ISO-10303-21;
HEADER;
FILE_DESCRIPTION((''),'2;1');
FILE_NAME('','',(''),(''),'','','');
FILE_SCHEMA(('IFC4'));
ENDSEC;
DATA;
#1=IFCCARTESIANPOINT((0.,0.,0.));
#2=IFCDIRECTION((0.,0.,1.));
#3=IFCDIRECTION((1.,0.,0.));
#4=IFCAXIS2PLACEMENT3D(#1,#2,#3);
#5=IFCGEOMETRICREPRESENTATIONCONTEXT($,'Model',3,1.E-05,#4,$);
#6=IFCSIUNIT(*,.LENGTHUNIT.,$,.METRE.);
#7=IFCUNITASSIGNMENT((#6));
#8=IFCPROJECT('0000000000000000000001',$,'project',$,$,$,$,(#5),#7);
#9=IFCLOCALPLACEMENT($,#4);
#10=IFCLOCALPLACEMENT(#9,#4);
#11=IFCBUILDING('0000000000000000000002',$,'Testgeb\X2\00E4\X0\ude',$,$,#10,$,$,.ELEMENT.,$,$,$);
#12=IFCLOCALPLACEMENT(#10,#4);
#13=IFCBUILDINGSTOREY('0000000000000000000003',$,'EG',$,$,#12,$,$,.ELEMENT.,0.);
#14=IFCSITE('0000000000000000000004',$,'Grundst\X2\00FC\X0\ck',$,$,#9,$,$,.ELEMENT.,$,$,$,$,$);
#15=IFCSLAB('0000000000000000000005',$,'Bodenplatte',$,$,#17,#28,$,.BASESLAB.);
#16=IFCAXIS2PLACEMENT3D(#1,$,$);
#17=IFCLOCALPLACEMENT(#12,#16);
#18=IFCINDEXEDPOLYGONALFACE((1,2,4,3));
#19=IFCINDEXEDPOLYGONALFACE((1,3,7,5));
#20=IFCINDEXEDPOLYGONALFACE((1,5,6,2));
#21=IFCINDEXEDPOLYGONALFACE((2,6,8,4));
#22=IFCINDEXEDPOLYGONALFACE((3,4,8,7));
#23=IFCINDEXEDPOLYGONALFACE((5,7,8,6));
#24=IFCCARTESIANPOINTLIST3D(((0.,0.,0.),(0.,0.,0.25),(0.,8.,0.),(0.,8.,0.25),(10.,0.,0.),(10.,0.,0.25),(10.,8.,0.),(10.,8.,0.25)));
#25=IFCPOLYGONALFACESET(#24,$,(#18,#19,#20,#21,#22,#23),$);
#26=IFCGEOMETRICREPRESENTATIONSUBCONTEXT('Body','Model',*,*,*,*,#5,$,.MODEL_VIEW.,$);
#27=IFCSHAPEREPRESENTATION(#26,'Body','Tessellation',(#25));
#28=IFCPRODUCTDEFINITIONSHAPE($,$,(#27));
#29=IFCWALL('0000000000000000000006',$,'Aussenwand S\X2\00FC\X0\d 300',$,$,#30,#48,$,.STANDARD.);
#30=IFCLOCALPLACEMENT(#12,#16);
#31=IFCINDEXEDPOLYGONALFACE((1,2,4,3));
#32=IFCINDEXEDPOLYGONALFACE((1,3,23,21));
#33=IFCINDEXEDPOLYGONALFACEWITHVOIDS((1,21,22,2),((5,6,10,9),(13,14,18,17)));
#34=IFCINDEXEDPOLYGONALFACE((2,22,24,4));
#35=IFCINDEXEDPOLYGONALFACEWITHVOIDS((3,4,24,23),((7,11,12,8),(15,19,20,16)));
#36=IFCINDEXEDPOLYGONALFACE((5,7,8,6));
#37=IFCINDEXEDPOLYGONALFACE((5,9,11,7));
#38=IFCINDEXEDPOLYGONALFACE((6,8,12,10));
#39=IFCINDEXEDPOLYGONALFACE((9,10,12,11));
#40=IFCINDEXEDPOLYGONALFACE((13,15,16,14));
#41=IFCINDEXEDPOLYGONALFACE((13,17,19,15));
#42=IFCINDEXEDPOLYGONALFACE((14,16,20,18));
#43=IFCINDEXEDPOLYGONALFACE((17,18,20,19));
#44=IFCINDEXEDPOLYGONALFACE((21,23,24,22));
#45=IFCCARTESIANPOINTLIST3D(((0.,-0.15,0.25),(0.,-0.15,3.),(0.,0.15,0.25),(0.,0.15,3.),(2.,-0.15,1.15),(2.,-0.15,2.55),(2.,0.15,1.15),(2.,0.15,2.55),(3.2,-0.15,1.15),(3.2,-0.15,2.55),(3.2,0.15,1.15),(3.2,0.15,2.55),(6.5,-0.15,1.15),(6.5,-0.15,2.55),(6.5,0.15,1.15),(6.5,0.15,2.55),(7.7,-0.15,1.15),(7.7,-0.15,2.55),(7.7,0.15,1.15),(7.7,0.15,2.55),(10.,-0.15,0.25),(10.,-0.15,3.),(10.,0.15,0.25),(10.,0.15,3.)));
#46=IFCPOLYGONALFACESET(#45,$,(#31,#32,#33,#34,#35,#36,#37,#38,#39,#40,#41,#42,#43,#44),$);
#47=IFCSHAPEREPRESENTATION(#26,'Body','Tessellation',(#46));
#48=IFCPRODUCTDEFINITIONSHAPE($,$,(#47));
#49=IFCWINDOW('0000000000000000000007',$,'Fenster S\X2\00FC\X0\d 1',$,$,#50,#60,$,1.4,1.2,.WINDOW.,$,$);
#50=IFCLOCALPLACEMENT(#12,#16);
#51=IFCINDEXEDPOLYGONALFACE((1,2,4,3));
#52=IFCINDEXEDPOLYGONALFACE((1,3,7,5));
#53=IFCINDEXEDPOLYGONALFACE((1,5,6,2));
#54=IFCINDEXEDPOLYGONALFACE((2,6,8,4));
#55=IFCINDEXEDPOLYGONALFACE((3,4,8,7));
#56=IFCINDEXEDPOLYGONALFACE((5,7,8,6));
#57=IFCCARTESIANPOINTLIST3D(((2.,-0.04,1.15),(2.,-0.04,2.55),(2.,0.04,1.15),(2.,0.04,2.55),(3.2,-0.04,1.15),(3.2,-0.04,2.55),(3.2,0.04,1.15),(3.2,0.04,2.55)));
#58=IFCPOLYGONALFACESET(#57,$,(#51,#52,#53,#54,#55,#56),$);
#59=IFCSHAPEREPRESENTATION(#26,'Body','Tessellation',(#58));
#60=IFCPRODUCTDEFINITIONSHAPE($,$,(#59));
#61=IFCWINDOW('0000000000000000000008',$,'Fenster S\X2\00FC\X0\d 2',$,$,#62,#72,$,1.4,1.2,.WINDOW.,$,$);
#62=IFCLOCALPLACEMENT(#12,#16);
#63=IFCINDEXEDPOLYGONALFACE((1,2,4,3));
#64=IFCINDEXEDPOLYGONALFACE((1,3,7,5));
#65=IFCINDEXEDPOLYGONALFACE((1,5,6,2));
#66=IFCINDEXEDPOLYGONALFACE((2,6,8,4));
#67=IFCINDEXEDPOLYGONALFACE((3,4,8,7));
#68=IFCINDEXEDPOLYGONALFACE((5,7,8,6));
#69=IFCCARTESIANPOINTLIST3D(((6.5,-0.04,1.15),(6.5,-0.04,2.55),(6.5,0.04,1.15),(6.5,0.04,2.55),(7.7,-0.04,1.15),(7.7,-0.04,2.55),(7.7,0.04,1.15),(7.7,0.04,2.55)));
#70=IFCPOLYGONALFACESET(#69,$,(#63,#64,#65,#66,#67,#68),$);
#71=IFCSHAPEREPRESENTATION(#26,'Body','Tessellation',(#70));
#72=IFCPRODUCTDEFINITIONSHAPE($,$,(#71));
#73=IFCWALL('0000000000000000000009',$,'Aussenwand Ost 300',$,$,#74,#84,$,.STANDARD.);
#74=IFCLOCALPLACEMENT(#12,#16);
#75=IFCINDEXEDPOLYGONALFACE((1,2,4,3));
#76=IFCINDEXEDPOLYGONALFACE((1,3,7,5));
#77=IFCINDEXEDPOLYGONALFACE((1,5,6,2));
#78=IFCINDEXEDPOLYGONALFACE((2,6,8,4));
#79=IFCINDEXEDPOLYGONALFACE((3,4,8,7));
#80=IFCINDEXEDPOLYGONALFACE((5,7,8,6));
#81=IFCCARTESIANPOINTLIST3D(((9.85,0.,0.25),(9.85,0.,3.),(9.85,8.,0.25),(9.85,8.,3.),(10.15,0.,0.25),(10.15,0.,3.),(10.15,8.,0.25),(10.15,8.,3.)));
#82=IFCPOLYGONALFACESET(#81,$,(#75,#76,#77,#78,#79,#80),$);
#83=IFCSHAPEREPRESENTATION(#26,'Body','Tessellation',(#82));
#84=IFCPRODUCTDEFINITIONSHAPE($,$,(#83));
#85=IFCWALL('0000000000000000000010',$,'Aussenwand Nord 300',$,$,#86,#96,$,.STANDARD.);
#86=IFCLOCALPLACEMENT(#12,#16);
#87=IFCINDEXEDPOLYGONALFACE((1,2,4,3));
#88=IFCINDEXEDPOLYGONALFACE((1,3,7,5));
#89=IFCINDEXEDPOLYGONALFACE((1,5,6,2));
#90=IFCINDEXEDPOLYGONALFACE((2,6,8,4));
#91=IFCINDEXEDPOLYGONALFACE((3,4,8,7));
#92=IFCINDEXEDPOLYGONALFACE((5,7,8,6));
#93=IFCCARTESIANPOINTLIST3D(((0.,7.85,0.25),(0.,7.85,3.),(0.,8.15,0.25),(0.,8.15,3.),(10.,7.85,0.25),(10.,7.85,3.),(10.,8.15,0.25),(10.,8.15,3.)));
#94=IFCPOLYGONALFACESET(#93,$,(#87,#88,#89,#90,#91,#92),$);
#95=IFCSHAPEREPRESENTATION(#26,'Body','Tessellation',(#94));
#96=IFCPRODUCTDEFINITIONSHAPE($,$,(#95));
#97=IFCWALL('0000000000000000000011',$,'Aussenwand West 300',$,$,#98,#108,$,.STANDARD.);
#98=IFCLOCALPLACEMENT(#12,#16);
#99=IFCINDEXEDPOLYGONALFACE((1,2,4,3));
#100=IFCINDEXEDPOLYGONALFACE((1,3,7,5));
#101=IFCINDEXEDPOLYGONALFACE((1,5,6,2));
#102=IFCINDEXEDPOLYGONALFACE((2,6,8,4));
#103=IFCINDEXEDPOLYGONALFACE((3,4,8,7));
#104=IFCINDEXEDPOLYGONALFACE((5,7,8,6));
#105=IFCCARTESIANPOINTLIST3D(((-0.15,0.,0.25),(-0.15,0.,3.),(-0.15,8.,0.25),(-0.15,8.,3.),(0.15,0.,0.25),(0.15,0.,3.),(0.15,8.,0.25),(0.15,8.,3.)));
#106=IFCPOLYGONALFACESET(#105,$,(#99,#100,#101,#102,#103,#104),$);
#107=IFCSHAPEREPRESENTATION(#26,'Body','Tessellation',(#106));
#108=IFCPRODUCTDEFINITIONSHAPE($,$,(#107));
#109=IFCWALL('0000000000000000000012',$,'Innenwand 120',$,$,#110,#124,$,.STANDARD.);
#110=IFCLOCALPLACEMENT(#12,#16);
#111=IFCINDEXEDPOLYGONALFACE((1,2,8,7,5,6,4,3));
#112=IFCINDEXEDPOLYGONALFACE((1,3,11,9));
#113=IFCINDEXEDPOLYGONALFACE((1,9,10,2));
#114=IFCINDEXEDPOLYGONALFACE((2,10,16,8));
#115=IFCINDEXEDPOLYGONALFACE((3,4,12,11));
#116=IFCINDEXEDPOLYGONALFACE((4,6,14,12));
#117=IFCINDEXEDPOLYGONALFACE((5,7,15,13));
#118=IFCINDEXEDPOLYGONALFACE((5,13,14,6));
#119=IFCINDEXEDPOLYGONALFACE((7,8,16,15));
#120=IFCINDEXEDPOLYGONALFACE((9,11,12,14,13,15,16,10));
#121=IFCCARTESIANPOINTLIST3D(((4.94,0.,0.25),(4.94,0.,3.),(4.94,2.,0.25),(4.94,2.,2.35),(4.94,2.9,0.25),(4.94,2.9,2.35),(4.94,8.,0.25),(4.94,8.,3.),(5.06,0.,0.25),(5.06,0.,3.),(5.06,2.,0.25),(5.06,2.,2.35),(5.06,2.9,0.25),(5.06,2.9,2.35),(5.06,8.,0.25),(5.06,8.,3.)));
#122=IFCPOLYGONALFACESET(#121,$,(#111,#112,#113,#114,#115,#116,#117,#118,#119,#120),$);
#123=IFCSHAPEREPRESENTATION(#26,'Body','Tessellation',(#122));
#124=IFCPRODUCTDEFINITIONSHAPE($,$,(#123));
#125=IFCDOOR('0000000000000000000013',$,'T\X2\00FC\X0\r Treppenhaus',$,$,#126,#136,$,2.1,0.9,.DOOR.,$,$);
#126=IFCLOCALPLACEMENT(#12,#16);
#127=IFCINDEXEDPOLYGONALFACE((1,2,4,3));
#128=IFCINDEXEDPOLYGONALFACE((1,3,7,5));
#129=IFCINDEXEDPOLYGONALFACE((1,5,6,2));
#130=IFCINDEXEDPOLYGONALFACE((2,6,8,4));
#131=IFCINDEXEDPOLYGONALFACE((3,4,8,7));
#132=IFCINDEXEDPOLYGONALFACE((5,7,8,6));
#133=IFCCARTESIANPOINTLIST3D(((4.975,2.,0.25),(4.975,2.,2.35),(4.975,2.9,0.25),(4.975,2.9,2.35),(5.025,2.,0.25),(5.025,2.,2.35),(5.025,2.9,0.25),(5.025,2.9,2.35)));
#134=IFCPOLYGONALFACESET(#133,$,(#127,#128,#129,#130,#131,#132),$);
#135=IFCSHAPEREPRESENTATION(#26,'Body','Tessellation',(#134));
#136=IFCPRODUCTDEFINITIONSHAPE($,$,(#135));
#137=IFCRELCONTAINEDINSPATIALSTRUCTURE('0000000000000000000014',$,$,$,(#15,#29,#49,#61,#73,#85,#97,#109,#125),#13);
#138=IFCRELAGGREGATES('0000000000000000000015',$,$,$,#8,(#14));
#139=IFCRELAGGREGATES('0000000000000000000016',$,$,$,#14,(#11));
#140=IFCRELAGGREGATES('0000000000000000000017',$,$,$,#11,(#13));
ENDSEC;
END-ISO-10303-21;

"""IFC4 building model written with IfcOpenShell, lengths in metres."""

from ifc_helpers import new_model, si_unit, frame, frame_2d, origin_with_axes, place, context, subcontext, project, spatial, rectangle, extrude, element, fill, save


model = new_model("IFC4")

# Units and contexts
model_context = context("Model", 3, precision=1e-05, world=origin_with_axes())
body_context = subcontext(model_context, "Body", "Model", "MODEL_VIEW")
ifc_project = project(units=[si_unit("LENGTHUNIT", "METRE")], contexts=[model_context])

# Site, building, storey
site_placement = place(None, origin_with_axes())
site = spatial("IfcSite", under=ifc_project, at=site_placement, Name="Grundstück", CompositionType="ELEMENT")
building_placement = place(site_placement, origin_with_axes())
building = spatial("IfcBuilding", under=site, at=building_placement, Name="Testgebäude", CompositionType="ELEMENT")
storey_placement = place(building_placement, origin_with_axes())
storey = spatial("IfcBuildingStorey", under=building, at=storey_placement, Name="EG", CompositionType="ELEMENT", Elevation=0.0)

# Slab
slab_placement = place(storey_placement, origin_with_axes())
element("IfcSlab", 1, at=slab_placement, inside=storey, Name="Bodenplatte", PredefinedType="BASESLAB", context=body_context, shape_type="SweptSolid", body=[
    extrude(rectangle(XDim=10.0, YDim=8.0, at=frame_2d((5.0, 4.0))), origin_with_axes(), (0.0, 0.0, 1.0), 0.25),
])

# Wall, openings, windows
wall_1_placement = place(storey_placement, frame((0.0, 0.0, 0.25), z_axis=(0.0, 0.0, 1.0), x_axis=(1.0, 0.0, 0.0)))
wall_1 = element("IfcWall", 2, at=wall_1_placement, inside=storey, Name="Aussenwand Süd 300", PredefinedType="STANDARD", context=body_context, shape_type="SweptSolid", body=[
    extrude(rectangle(XDim=10.0, YDim=0.3, at=frame_2d((5.0, 0.0))), origin_with_axes(), (0.0, 0.0, 1.0), 2.75),
])
opening_1_placement = place(storey_placement, frame((2.0, 0.0, 1.15), z_axis=(0.0, 0.0, 1.0), x_axis=(1.0, 0.0, 0.0)))
opening_1 = element("IfcOpeningElement", 3, at=opening_1_placement, cuts=wall_1, PredefinedType="OPENING", context=body_context, shape_type="SweptSolid", body=[
    extrude(rectangle(XDim=1.2, YDim=0.5, at=frame_2d((0.6, 0.0))), origin_with_axes(), (0.0, 0.0, 1.0), 1.4),
])
opening_2_placement = place(storey_placement, frame((6.5, 0.0, 1.15), z_axis=(0.0, 0.0, 1.0), x_axis=(1.0, 0.0, 0.0)))
opening_2 = element("IfcOpeningElement", 4, at=opening_2_placement, cuts=wall_1, PredefinedType="OPENING", context=body_context, shape_type="SweptSolid", body=[
    extrude(rectangle(XDim=1.2, YDim=0.5, at=frame_2d((0.6, 0.0))), origin_with_axes(), (0.0, 0.0, 1.0), 1.4),
])
window_1_placement = place(storey_placement, frame((2.0, 0.0, 1.15), z_axis=(0.0, 0.0, 1.0), x_axis=(1.0, 0.0, 0.0)))
window_1 = element("IfcWindow", 5, at=window_1_placement, inside=storey, Name="Fenster Süd 1", OverallHeight=1.4, OverallWidth=1.2, PredefinedType="WINDOW", context=body_context, shape_type="SweptSolid", body=[
    extrude(rectangle(XDim=1.2, YDim=0.08, at=frame_2d((0.6, 0.0))), origin_with_axes(), (0.0, 0.0, 1.0), 1.4),
])
fill(opening_1, window_1)
window_2_placement = place(storey_placement, frame((6.5, 0.0, 1.15), z_axis=(0.0, 0.0, 1.0), x_axis=(1.0, 0.0, 0.0)))
window_2 = element("IfcWindow", 6, at=window_2_placement, inside=storey, Name="Fenster Süd 2", OverallHeight=1.4, OverallWidth=1.2, PredefinedType="WINDOW", context=body_context, shape_type="SweptSolid", body=[
    extrude(rectangle(XDim=1.2, YDim=0.08, at=frame_2d((0.6, 0.0))), origin_with_axes(), (0.0, 0.0, 1.0), 1.4),
])
fill(opening_2, window_2)

# Walls
wall_2_placement = place(storey_placement, frame((10.0, 0.0, 0.25), z_axis=(0.0, 0.0, 1.0), x_axis=(0.0, 1.0, 0.0)))
element("IfcWall", 7, at=wall_2_placement, inside=storey, Name="Aussenwand Ost 300", PredefinedType="STANDARD", context=body_context, shape_type="SweptSolid", body=[
    extrude(rectangle(XDim=8.0, YDim=0.3, at=frame_2d((4.0, 0.0))), origin_with_axes(), (0.0, 0.0, 1.0), 2.75),
])
wall_3_placement = place(storey_placement, frame((10.0, 8.0, 0.25), z_axis=(0.0, 0.0, 1.0), x_axis=(-1.0, 0.0, 0.0)))
element("IfcWall", 8, at=wall_3_placement, inside=storey, Name="Aussenwand Nord 300", PredefinedType="STANDARD", context=body_context, shape_type="SweptSolid", body=[
    extrude(rectangle(XDim=10.0, YDim=0.3, at=frame_2d((5.0, 0.0))), origin_with_axes(), (0.0, 0.0, 1.0), 2.75),
])
wall_4_placement = place(storey_placement, frame((0.0, 8.0, 0.25), z_axis=(0.0, 0.0, 1.0), x_axis=(0.0, -1.0, 0.0)))
element("IfcWall", 9, at=wall_4_placement, inside=storey, Name="Aussenwand West 300", PredefinedType="STANDARD", context=body_context, shape_type="SweptSolid", body=[
    extrude(rectangle(XDim=8.0, YDim=0.3, at=frame_2d((4.0, 0.0))), origin_with_axes(), (0.0, 0.0, 1.0), 2.75),
])

# Wall, opening, door
wall_5_placement = place(storey_placement, frame((5.0, 0.0, 0.25), z_axis=(0.0, 0.0, 1.0), x_axis=(0.0, 1.0, 0.0)))
wall_5 = element("IfcWall", 10, at=wall_5_placement, inside=storey, Name="Innenwand 120", PredefinedType="STANDARD", context=body_context, shape_type="SweptSolid", body=[
    extrude(rectangle(XDim=8.0, YDim=0.12, at=frame_2d((4.0, 0.0))), origin_with_axes(), (0.0, 0.0, 1.0), 2.75),
])
opening_3_placement = place(storey_placement, frame((5.0, 2.0, 0.25), z_axis=(0.0, 0.0, 1.0), x_axis=(0.0, 1.0, 0.0)))
opening_3 = element("IfcOpeningElement", 11, at=opening_3_placement, cuts=wall_5, PredefinedType="OPENING", context=body_context, shape_type="SweptSolid", body=[
    extrude(rectangle(XDim=0.9, YDim=0.4, at=frame_2d((0.45, 0.0))), origin_with_axes(), (0.0, 0.0, 1.0), 2.1),
])
door_placement = place(storey_placement, frame((5.0, 2.0, 0.25), z_axis=(0.0, 0.0, 1.0), x_axis=(0.0, 1.0, 0.0)))
door = element("IfcDoor", 12, at=door_placement, inside=storey, Name="Tür Treppenhaus", OverallHeight=2.1, OverallWidth=0.9, PredefinedType="DOOR", context=body_context, shape_type="SweptSolid", body=[
    extrude(rectangle(XDim=0.9, YDim=0.05, at=frame_2d((0.45, 0.0))), origin_with_axes(), (0.0, 0.0, 1.0), 2.1),
])
fill(opening_3, door)

save(model, "model.ifc")
